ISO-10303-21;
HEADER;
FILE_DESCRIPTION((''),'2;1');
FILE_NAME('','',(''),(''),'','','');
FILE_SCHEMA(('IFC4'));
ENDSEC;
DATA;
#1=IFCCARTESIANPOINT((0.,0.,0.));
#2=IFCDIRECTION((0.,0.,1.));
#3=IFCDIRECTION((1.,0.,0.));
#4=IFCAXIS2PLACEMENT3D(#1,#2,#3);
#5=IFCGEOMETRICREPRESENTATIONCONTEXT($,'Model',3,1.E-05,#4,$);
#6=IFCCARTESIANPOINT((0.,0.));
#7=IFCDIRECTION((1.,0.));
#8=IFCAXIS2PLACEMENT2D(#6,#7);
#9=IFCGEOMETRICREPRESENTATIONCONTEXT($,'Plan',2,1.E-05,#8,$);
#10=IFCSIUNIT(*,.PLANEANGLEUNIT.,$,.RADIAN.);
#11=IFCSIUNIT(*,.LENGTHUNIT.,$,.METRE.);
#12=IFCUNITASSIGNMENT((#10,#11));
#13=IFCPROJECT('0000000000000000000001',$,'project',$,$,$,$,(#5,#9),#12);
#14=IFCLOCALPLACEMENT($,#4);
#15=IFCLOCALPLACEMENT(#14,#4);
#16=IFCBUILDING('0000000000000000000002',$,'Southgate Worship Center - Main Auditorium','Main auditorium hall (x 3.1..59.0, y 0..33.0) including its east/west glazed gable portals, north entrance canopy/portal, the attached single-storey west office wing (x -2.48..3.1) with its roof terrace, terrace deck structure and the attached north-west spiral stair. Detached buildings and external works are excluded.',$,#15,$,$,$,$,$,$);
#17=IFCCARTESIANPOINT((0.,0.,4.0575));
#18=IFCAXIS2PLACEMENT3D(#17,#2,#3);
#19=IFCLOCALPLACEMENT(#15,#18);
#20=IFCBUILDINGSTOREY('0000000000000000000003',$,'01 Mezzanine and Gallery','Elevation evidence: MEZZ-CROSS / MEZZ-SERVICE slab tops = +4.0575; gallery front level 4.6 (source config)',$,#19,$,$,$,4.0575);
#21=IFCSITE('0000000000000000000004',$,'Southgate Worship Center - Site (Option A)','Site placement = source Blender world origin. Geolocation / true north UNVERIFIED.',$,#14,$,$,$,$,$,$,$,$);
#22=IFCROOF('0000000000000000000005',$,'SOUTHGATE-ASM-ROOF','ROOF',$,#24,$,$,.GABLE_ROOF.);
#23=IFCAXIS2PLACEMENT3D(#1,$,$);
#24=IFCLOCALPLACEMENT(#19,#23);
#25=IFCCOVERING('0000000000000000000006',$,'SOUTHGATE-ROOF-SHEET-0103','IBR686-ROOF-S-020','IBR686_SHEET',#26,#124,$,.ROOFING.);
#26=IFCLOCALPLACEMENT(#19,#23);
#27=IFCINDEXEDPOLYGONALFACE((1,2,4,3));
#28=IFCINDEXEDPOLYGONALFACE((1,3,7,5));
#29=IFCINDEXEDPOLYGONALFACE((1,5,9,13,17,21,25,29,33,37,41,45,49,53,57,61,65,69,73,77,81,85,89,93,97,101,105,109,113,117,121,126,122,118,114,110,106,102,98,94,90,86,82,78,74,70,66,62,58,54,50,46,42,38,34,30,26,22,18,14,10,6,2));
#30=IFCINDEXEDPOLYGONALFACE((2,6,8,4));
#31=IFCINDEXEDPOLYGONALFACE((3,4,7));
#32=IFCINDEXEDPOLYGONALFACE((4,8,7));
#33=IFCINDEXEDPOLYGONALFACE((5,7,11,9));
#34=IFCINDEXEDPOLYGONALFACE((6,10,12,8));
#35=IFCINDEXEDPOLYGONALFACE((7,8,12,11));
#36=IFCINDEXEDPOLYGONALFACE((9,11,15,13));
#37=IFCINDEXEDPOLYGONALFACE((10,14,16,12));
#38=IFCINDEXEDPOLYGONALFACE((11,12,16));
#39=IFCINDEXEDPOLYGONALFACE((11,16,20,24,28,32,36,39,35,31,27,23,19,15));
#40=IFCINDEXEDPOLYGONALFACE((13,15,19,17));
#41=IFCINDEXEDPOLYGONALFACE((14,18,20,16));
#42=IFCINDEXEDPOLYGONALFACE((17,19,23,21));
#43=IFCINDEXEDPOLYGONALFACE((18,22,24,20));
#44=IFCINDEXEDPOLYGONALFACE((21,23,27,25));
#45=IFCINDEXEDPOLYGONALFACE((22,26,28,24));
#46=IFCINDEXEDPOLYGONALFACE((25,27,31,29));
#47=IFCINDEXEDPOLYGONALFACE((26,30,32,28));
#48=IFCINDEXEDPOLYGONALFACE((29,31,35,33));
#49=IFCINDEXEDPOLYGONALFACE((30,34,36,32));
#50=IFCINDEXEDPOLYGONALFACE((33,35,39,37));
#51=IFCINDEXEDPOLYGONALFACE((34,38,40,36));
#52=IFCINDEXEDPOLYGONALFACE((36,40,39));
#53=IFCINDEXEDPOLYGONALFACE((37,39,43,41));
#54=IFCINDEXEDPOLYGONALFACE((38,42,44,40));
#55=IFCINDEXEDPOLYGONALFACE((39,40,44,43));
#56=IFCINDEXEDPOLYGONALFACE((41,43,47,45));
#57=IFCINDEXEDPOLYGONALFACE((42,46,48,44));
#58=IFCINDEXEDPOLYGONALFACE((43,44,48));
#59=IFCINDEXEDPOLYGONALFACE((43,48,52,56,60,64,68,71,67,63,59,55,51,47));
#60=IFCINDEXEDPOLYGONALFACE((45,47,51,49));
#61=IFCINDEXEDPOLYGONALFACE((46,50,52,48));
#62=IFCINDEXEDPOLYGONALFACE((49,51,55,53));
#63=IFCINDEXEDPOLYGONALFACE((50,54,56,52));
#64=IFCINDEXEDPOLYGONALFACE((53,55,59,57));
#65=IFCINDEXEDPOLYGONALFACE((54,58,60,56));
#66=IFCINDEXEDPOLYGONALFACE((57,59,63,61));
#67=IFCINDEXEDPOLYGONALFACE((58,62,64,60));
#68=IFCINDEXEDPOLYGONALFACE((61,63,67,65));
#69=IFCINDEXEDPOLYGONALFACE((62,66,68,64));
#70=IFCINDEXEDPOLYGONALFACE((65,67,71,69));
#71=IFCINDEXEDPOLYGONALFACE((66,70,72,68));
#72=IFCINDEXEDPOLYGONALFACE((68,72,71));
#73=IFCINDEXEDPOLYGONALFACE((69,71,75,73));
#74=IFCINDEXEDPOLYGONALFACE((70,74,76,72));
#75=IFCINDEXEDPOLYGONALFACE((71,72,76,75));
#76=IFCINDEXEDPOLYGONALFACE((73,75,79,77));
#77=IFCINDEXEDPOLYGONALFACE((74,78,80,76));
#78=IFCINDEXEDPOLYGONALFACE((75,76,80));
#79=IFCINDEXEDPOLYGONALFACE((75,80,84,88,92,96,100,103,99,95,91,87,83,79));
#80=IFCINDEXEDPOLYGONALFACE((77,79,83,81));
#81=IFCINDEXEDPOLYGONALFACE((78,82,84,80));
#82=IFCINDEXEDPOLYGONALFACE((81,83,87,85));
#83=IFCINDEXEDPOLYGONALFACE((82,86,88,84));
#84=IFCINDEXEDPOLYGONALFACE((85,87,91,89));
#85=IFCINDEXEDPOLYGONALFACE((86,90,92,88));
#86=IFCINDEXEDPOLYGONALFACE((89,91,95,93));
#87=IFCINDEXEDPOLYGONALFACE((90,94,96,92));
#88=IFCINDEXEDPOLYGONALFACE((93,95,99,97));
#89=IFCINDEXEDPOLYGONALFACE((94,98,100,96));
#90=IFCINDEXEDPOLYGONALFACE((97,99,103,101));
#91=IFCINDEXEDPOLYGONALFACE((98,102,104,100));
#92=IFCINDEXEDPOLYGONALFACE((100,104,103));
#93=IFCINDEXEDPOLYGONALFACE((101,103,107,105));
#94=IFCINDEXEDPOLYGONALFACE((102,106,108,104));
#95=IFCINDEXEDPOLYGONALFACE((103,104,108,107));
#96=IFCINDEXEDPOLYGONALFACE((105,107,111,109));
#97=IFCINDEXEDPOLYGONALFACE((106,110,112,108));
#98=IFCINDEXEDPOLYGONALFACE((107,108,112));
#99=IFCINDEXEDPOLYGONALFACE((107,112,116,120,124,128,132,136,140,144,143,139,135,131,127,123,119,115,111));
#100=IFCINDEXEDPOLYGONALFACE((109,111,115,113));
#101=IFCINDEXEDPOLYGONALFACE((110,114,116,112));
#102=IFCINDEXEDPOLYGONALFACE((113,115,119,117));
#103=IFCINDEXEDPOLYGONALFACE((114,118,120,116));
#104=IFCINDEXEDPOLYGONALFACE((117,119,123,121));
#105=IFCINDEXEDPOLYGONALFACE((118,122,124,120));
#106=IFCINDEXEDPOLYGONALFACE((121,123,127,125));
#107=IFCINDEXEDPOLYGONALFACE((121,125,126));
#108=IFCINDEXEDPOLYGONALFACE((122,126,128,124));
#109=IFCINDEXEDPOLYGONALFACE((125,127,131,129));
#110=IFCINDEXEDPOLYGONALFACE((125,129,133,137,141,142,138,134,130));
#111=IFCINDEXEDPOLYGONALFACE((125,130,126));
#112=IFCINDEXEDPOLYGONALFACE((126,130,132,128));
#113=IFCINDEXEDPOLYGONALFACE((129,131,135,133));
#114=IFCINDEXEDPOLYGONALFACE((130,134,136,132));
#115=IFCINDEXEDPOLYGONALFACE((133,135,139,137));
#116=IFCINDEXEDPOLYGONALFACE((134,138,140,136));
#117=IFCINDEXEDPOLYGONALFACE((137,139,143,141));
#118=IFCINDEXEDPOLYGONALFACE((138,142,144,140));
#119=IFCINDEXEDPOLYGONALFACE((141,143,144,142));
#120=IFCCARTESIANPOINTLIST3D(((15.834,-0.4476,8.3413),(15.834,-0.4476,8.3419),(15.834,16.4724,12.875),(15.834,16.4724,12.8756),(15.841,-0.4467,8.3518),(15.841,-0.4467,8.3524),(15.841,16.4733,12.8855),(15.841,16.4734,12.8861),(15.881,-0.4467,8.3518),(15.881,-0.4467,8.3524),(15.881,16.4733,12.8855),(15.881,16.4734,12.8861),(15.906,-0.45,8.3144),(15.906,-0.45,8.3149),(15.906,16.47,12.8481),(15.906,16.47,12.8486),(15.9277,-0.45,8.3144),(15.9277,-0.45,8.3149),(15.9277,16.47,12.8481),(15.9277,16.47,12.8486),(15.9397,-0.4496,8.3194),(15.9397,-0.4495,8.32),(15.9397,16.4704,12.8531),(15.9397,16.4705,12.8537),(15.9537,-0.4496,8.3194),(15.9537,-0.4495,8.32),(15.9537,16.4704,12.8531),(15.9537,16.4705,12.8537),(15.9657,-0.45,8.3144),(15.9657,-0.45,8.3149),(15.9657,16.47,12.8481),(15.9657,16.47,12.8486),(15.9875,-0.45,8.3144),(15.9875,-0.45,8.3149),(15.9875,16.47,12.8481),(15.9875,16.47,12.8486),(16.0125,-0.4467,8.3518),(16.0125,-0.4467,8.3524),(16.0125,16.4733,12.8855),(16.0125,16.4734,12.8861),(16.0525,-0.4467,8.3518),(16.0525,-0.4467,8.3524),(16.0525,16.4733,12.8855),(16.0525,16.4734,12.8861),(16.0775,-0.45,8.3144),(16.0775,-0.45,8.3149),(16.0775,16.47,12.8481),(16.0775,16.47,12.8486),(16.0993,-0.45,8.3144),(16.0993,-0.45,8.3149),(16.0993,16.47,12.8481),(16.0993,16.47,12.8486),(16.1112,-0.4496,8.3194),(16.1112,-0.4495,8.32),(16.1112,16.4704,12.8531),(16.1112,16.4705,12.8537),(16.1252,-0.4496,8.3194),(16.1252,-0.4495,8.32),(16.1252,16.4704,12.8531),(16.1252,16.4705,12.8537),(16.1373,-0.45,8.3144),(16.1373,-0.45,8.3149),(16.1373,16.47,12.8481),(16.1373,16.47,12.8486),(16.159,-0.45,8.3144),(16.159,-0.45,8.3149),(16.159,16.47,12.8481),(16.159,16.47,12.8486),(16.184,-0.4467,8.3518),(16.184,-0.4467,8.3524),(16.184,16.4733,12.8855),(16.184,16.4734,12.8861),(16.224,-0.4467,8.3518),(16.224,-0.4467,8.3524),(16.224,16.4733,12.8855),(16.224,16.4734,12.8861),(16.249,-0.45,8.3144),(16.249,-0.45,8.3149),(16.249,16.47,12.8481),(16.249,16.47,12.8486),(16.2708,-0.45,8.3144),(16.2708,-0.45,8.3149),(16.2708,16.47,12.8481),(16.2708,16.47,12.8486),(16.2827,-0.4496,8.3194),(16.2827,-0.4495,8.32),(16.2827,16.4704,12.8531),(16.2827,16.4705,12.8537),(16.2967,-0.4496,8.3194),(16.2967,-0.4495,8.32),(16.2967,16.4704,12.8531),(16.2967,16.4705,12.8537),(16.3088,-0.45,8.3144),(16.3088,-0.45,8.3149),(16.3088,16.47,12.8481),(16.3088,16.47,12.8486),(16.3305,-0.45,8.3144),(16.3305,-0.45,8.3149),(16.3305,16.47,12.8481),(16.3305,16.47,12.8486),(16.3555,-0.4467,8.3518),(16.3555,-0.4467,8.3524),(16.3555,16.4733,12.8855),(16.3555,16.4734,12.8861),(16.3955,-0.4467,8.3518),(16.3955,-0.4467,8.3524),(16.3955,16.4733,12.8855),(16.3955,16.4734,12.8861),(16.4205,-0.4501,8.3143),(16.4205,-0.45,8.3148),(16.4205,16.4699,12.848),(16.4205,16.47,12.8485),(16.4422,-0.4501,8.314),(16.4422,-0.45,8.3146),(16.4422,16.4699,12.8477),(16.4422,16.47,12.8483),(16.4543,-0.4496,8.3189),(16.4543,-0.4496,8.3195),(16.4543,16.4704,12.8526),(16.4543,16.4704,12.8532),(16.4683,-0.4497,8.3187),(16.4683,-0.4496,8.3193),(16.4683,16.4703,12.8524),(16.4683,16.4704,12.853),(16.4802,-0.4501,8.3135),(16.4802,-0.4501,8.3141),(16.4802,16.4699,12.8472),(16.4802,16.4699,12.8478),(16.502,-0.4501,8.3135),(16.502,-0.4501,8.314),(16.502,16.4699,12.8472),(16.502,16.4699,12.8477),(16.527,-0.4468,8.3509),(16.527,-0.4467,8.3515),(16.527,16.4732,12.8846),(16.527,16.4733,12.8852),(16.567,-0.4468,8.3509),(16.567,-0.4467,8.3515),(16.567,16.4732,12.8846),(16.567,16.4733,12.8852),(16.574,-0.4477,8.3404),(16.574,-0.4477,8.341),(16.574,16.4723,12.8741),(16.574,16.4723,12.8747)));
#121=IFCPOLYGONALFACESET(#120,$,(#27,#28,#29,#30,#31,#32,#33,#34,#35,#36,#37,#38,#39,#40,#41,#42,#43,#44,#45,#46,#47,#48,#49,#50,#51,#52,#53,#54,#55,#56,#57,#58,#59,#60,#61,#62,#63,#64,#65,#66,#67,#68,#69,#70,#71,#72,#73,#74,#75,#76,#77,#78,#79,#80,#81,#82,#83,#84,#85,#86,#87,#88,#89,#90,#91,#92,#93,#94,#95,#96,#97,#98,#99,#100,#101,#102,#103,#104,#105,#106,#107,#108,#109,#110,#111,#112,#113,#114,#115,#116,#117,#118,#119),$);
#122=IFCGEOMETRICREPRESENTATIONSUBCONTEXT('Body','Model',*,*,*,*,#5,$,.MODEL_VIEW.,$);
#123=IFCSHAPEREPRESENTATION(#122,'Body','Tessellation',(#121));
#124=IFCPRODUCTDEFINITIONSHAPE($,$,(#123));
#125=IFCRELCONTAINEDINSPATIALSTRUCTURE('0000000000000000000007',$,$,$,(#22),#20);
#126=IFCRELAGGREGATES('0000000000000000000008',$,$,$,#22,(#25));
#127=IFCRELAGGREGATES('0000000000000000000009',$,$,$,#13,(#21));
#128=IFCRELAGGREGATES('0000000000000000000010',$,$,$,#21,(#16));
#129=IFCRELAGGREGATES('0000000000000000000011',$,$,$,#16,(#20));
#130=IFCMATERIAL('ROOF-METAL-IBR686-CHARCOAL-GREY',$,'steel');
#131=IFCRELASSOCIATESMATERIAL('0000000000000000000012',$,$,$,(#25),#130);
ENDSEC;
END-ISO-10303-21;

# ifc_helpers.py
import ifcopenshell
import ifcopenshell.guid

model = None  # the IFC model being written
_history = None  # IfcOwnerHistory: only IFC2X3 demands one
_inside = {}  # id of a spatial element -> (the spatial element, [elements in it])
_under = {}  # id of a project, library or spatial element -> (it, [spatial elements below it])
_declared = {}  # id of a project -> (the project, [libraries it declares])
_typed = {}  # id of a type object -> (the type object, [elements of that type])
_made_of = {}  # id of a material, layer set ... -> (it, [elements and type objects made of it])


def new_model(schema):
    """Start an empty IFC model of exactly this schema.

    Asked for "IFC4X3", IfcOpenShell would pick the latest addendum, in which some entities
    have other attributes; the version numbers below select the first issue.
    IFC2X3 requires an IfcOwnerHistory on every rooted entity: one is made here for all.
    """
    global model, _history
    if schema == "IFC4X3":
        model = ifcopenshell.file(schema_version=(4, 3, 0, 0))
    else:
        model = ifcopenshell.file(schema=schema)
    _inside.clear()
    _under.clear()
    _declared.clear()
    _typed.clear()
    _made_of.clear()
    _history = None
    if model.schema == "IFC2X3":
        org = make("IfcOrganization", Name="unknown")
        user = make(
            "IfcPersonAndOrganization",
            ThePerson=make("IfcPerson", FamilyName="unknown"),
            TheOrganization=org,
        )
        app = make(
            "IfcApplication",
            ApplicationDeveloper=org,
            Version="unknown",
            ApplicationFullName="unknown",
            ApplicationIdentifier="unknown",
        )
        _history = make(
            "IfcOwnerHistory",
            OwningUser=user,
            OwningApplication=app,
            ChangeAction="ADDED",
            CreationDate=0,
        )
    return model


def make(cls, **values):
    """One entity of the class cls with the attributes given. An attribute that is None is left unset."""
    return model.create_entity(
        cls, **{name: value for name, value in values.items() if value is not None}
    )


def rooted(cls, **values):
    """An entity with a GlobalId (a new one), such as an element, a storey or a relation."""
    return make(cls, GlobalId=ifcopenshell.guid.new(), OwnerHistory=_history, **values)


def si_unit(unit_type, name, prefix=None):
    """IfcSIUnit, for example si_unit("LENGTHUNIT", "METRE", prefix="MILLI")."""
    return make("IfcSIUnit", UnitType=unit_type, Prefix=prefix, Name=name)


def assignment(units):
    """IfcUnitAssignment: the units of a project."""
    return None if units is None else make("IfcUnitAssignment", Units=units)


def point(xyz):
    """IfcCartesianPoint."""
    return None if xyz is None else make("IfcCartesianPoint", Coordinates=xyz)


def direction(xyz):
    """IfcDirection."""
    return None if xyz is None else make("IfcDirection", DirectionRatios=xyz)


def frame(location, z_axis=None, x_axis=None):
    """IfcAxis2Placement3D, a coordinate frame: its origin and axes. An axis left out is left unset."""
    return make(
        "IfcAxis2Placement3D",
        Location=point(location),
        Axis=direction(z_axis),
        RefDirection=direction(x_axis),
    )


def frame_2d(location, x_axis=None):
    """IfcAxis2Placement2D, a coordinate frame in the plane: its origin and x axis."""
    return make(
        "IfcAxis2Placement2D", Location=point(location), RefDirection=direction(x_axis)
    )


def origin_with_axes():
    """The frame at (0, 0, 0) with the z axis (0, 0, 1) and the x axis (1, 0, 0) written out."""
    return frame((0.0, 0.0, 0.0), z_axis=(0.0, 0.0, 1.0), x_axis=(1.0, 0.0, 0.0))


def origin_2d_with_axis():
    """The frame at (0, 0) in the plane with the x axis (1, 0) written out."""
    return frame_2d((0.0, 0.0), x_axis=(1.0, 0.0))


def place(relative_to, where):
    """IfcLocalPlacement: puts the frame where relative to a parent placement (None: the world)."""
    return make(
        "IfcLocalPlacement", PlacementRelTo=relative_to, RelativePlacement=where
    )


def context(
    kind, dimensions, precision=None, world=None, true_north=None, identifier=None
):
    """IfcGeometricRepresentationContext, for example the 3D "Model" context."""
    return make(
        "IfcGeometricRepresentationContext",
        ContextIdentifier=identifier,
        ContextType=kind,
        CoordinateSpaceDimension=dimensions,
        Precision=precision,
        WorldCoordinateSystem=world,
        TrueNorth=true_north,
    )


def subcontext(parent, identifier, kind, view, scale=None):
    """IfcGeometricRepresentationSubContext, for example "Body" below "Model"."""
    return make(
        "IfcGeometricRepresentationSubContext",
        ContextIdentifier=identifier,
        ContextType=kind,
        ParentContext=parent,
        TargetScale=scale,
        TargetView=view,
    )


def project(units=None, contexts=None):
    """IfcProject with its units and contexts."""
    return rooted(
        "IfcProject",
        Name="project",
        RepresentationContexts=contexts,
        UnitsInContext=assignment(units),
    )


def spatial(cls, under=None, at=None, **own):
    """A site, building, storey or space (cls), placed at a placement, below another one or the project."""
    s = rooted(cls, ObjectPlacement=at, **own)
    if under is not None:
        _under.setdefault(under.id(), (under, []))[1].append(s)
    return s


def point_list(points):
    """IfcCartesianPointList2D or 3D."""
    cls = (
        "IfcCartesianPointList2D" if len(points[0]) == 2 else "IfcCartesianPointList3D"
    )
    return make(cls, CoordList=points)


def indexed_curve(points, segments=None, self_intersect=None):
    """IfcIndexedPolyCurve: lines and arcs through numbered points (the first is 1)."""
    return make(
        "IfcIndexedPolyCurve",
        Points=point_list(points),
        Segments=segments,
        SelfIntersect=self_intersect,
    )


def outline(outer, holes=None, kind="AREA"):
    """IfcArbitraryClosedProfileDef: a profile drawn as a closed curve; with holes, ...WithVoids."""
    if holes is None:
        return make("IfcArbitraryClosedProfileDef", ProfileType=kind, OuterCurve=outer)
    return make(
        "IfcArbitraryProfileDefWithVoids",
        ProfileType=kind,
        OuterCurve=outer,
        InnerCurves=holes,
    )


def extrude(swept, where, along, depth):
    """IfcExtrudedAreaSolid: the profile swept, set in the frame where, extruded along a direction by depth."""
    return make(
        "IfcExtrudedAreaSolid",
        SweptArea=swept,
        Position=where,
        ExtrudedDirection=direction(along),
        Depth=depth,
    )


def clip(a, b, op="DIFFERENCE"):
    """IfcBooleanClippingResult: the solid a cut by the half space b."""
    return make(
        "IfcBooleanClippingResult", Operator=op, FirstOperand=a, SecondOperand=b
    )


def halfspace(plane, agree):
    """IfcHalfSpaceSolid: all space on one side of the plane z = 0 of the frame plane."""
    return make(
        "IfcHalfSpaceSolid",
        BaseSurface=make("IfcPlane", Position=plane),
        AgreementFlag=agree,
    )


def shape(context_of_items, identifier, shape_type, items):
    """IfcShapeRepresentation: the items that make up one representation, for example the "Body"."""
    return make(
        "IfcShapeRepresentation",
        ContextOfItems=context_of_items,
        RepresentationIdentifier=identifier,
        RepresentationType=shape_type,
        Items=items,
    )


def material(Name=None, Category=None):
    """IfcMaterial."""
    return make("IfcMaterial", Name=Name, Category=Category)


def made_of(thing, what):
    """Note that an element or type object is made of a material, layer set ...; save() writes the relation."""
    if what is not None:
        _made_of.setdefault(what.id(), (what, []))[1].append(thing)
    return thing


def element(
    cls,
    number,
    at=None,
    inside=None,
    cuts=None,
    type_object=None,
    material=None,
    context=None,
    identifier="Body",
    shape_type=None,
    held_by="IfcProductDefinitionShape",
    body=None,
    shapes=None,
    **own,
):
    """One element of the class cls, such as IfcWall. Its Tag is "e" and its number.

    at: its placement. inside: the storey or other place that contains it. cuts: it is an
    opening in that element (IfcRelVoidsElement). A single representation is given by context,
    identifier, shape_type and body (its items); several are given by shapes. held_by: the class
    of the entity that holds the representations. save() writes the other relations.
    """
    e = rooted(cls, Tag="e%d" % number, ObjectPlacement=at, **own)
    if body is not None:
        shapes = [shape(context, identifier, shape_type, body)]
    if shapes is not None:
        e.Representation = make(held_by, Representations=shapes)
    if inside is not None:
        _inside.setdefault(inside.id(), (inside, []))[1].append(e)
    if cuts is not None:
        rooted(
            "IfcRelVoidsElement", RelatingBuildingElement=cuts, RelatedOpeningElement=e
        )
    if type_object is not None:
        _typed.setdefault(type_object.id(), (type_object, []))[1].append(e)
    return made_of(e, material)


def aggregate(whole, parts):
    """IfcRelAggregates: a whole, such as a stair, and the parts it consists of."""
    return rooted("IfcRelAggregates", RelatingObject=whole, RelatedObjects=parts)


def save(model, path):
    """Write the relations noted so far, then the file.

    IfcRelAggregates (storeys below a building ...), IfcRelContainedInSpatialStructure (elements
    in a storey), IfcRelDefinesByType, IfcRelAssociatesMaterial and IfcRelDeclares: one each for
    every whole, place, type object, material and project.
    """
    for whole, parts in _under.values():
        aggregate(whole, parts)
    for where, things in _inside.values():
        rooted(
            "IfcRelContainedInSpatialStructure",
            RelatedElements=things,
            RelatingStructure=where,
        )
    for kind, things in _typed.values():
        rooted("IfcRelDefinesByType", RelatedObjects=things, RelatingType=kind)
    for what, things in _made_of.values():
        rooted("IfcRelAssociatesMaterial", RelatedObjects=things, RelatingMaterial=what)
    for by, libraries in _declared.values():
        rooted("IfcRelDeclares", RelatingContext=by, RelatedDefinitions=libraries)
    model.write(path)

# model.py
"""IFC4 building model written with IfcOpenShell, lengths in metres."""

from ifc_helpers import new_model, si_unit, frame, origin_with_axes, origin_2d_with_axis, place, context, subcontext, project, spatial, indexed_curve, outline, extrude, clip, halfspace, material, element, aggregate, save


model = new_model("IFC4")

# Units and contexts
model_context = context("Model", 3, precision=1e-05, world=origin_with_axes())
plan_context = context("Plan", 2, precision=1e-05, world=origin_2d_with_axis())
body_context = subcontext(model_context, "Body", "Model", "MODEL_VIEW")
ifc_project = project(units=[si_unit("PLANEANGLEUNIT", "RADIAN"), si_unit("LENGTHUNIT", "METRE")], contexts=[model_context, plan_context])

# Site, building, storey
site_placement = place(None, origin_with_axes())
site = spatial("IfcSite", under=ifc_project, at=site_placement, Name="Southgate Worship Center - Site (Option A)", Description="Site placement = source Blender world origin. Geolocation / true north UNVERIFIED.")
building_placement = place(site_placement, origin_with_axes())
building = spatial("IfcBuilding", under=site, at=building_placement, Name="Southgate Worship Center - Main Auditorium", Description="Main auditorium hall (x 3.1..59.0, y 0..33.0) including its east/west glazed gable portals, north entrance canopy/portal, the attached single-storey west office wing (x -2.48..3.1) with its roof terrace, terrace deck structure and the attached north-west spiral stair. Detached buildings and external works are excluded.")
storey_placement = place(building_placement, frame((0.0, 0.0, 4.0575), z_axis=(0.0, 0.0, 1.0), x_axis=(1.0, 0.0, 0.0)))
storey = spatial("IfcBuildingStorey", under=building, at=storey_placement, Name="01 Mezzanine and Gallery", Description="Elevation evidence: MEZZ-CROSS / MEZZ-SERVICE slab tops = +4.0575; gallery front level 4.6 (source config)", Elevation=4.0575)

# Roof, covering
roof_placement = place(storey_placement, origin_with_axes())
roof = element("IfcRoof", 1, at=roof_placement, inside=storey, Name="SOUTHGATE-ASM-ROOF", Description="ROOF", PredefinedType="GABLE_ROOF")
ifc_material_1 = material(Name="ROOF-METAL-IBR686-CHARCOAL-GREY", Category="steel")
covering_1_placement = place(roof_placement, frame((15.834, -0.4501, 8.3135), z_axis=(0.0, 0.0, 1.0), x_axis=(1.0, 0.0, 0.0)))
covering_1 = element("IfcCovering", 2, at=covering_1_placement, material=ifc_material_1, Name="SOUTHGATE-ROOF-SHEET-0103", Description="IBR686-ROOF-S-020", ObjectType="IBR686_SHEET", PredefinedType="ROOFING", context=body_context, shape_type="Clipping", body=[
    clip(clip(extrude(outline(indexed_curve([(0.0, 0.0), (0.025, 0.0353), (0.065, 0.0353), (0.072, 0.0254), (0.072, 0.0259), (0.065, 0.0358), (0.025, 0.0358), (0.0, 0.0005), (-0.0217, 0.0005), (-0.0337, 0.0053), (-0.0477, 0.0053), (-0.0597, 0.0005), (-0.0815, 0.0005), (-0.1065, 0.0358), (-0.1465, 0.0358), (-0.1715, 0.0005), (-0.1933, 0.0005), (-0.2052, 0.0053), (-0.2192, 0.0053), (-0.2313, 0.0005), (-0.253, 0.0005), (-0.278, 0.0358), (-0.318, 0.0358), (-0.343, 0.0005), (-0.3647, 0.0005), (-0.3767, 0.0053), (-0.3907, 0.0053), (-0.4028, 0.0005), (-0.4245, 0.0005), (-0.4495, 0.0358), (-0.4895, 0.0358), (-0.5145, 0.0004), (-0.5362, 0.0002), (-0.5483, 0.0048), (-0.5623, 0.0046), (-0.5742, -0.0003), (-0.596, -0.0004), (-0.621, 0.0349), (-0.661, 0.0349), (-0.668, 0.0251), (-0.668, 0.0246), (-0.661, 0.0344), (-0.621, 0.0344), (-0.596, -0.0009), (-0.5742, -0.0008), (-0.5623, 0.0041), (-0.5483, 0.0043), (-0.5362, -0.0003), (-0.5145, -0.0001), (-0.4895, 0.0353), (-0.4495, 0.0353), (-0.4245, 0.0), (-0.4028, 0.0), (-0.3907, 0.0048), (-0.3767, 0.0048), (-0.3647, 0.0), (-0.343, 0.0), (-0.318, 0.0353), (-0.278, 0.0353), (-0.253, 0.0), (-0.2313, 0.0), (-0.2192, 0.0048), (-0.2052, 0.0048), (-0.1933, 0.0), (-0.1715, 0.0), (-0.1465, 0.0353), (-0.1065, 0.0353), (-0.0815, 0.0), (-0.0597, 0.0), (-0.0477, 0.0048), (-0.0337, 0.0048), (-0.0217, 0.0), (0.0, 0.0)], self_intersect=False)), frame((0.072, -0.0003, 0.0008), z_axis=(0.0, 0.965926, 0.258819), x_axis=(-1.0, 0.0, 0.0)), (0.0, 0.0, 1.0), 17.5303), halfspace(frame((0.37, 0.0012, 0.014), z_axis=(0.0, -0.996022, 0.089113), x_axis=(1.0, 0.0, 0.0)), False)), halfspace(frame((0.37, 16.9212, 4.5477), z_axis=(0.0, 0.996021, -0.089119), x_axis=(-1.0, 0.0, 0.0)), False)),
])
aggregate(roof, [covering_1])

save(model, "model.ifc")
